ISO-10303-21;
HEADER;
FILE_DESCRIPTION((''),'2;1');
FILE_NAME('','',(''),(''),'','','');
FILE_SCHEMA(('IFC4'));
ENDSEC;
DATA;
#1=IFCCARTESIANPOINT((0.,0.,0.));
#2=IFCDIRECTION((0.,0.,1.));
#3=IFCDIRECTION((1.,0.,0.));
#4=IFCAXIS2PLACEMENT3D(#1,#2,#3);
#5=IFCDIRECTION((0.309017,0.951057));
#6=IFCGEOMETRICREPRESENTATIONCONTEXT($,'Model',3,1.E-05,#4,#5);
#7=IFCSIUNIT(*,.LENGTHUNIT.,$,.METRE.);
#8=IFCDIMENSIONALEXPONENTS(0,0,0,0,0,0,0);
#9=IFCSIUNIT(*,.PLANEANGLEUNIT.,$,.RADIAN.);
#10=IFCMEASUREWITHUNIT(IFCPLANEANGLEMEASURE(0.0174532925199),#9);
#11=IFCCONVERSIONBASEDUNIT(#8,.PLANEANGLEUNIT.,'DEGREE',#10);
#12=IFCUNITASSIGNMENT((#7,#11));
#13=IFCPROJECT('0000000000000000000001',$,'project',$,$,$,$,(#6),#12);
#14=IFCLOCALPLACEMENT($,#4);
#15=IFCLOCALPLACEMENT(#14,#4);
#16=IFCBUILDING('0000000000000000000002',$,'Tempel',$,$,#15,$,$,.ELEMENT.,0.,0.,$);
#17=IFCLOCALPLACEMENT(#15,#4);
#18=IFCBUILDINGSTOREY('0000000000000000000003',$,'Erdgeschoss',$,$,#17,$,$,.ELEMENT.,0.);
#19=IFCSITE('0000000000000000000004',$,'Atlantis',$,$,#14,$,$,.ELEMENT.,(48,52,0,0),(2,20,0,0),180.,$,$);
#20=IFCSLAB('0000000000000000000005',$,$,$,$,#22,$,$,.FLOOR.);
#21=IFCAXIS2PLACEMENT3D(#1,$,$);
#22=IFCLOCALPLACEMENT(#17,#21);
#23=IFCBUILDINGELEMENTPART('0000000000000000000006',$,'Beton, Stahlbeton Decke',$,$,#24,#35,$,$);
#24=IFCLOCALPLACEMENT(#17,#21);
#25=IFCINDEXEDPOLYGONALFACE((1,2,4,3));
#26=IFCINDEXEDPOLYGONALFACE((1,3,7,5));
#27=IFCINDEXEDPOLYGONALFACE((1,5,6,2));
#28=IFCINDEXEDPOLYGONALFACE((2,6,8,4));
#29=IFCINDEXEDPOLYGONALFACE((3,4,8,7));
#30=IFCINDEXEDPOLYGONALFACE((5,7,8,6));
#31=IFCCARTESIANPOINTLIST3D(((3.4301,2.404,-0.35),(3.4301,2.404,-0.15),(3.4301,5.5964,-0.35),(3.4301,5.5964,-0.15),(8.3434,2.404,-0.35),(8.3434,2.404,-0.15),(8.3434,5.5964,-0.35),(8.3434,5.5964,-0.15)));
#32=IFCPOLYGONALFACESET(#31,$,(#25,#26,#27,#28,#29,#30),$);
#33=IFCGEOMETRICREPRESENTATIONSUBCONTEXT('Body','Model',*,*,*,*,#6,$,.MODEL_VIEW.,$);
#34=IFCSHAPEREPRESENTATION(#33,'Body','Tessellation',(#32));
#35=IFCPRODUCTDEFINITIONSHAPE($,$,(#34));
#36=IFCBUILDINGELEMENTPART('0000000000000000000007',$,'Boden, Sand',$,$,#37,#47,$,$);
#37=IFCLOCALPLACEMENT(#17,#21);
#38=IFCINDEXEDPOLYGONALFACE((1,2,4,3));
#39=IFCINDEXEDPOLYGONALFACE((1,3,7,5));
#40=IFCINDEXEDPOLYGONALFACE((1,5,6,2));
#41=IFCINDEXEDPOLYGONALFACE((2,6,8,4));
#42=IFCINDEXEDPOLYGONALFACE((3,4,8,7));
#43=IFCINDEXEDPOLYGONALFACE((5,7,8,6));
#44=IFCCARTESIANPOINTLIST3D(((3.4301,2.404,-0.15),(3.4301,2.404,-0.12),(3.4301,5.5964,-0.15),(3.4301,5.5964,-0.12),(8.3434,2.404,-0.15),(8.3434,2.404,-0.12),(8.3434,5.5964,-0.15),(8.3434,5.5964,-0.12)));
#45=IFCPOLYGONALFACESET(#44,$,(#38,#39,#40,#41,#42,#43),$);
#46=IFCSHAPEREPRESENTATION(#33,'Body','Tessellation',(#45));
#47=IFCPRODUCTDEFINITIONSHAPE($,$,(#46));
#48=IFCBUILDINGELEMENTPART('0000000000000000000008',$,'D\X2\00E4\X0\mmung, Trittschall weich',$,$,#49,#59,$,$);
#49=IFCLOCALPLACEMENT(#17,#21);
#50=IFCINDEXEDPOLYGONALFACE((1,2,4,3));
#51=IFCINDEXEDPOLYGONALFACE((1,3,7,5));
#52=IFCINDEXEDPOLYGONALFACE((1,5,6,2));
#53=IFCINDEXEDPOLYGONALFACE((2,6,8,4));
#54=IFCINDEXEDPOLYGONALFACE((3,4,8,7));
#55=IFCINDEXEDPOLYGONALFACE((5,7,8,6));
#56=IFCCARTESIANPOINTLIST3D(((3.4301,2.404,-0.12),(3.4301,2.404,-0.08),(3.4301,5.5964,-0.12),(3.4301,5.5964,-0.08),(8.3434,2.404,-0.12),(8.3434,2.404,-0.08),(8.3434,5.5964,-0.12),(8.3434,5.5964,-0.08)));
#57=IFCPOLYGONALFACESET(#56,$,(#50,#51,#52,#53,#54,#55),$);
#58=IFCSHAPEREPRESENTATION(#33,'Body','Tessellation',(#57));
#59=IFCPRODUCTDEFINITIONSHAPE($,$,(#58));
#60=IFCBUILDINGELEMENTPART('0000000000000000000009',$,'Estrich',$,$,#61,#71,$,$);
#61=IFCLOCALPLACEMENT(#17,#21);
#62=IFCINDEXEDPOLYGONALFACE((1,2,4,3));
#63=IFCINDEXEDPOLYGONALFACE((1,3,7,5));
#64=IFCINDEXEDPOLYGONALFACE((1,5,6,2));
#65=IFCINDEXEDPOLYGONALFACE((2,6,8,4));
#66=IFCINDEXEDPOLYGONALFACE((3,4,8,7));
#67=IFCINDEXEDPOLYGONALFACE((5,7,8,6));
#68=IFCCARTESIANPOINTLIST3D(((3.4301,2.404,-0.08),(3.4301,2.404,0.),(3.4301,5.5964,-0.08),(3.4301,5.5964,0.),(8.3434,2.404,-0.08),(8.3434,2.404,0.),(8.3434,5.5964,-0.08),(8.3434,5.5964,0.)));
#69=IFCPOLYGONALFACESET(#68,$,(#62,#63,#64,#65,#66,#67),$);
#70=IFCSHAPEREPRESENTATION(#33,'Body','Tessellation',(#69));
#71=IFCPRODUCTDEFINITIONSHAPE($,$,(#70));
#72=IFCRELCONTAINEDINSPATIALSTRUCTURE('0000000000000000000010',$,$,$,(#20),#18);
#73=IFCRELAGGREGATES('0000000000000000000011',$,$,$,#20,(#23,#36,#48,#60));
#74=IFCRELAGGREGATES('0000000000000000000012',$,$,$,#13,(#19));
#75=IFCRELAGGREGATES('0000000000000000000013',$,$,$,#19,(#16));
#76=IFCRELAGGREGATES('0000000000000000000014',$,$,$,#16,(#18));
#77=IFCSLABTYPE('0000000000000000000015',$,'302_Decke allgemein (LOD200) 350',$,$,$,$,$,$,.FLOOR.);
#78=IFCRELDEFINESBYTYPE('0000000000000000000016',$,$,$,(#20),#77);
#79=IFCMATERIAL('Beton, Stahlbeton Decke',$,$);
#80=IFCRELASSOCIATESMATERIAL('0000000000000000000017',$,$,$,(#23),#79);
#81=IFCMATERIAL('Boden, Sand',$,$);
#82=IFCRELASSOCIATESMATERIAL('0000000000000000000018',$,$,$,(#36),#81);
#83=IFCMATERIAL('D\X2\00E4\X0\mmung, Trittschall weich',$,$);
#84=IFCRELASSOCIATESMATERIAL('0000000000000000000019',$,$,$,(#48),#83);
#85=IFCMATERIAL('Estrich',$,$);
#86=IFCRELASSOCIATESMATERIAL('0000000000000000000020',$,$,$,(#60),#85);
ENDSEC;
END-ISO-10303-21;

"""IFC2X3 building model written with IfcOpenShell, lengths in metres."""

from ifc_helpers import new_model, entity, si_unit, converted_unit, direction, frame, origin_with_axes, place, context, subcontext, project, spatial, polyline, outline, extrude, material, type_object, element, aggregate, save


model = new_model("IFC2X3")

# Units and contexts
model_context = context("Model", 3, precision=1e-05, world=origin_with_axes(), true_north=direction((0.309017, 0.951057)))
body_context = subcontext(model_context, "Body", "Model", "MODEL_VIEW")
ifc_project = project(units=[si_unit("LENGTHUNIT", "METRE"), converted_unit("PLANEANGLEUNIT", "DEGREE", entity("IfcPlaneAngleMeasure", 0.0174532925199), si_unit("PLANEANGLEUNIT", "RADIAN"), dimensions=[0, 0, 0, 0, 0, 0, 0])], contexts=[model_context])

# Site, building, storey
site_placement = place(None, origin_with_axes())
site = spatial("IfcSite", under=ifc_project, at=site_placement, Name="Atlantis", CompositionType="ELEMENT", RefLatitude=(48, 52, 0, 0), RefLongitude=(2, 20, 0, 0), RefElevation=180.0)
building_placement = place(site_placement, origin_with_axes())
building = spatial("IfcBuilding", under=site, at=building_placement, Name="Tempel", CompositionType="ELEMENT", ElevationOfRefHeight=0.0, ElevationOfTerrain=0.0)
storey_placement = place(building_placement, origin_with_axes())
storey = spatial("IfcBuildingStorey", under=building, at=storey_placement, Name="Erdgeschoss", CompositionType="ELEMENT", Elevation=0.0)

# Slab, building element parts
slab_type = type_object("IfcSlabType", Name="302_Decke allgemein (LOD200) 350", PredefinedType="FLOOR")
slab_placement = place(storey_placement, frame((3.4301, 2.404, -0.15), z_axis=(0.0, 0.0, 1.0), x_axis=(1.0, 0.0, 0.0)))
slab = element("IfcSlab", 1, at=slab_placement, inside=storey, type_object=slab_type, PredefinedType="FLOOR")
ifc_material_1 = material(Name="Beton, Stahlbeton Decke")
building_element_part_1_placement = place(slab_placement, origin_with_axes())
building_element_part_1 = element("IfcBuildingElementPart", 2, at=building_element_part_1_placement, material=ifc_material_1, Name="Beton, Stahlbeton Decke", context=body_context, shape_type="SweptSolid", body=[
    extrude(outline(polyline([(0.0, 0.0), (4.9133, 0.0), (4.9133, 3.1924), (0.0, 3.1924), (0.0, 0.0)])), frame((0.0, 0.0, -0.2), z_axis=(0.0, 0.0, 1.0), x_axis=(1.0, 0.0, 0.0)), (0.0, 0.0, 1.0), 0.2),
])
ifc_material_2 = material(Name="Boden, Sand")
building_element_part_2_placement = place(slab_placement, origin_with_axes())
building_element_part_2 = element("IfcBuildingElementPart", 3, at=building_element_part_2_placement, material=ifc_material_2, Name="Boden, Sand", context=body_context, shape_type="SweptSolid", body=[
    extrude(outline(polyline([(0.0, 0.0), (4.9133, 0.0), (4.9133, 3.1924), (0.0, 3.1924), (0.0, 0.0)])), origin_with_axes(), (0.0, 0.0, 1.0), 0.03),
])
ifc_material_3 = material(Name="Dämmung, Trittschall weich")
building_element_part_3_placement = place(slab_placement, origin_with_axes())
building_element_part_3 = element("IfcBuildingElementPart", 4, at=building_element_part_3_placement, material=ifc_material_3, Name="Dämmung, Trittschall weich", context=body_context, shape_type="SweptSolid", body=[
    extrude(outline(polyline([(0.0, 0.0), (4.9133, 0.0), (4.9133, 3.1924), (0.0, 3.1924), (0.0, 0.0)])), frame((0.0, 0.0, 0.03), z_axis=(0.0, 0.0, 1.0), x_axis=(1.0, 0.0, 0.0)), (0.0, 0.0, 1.0), 0.04),
])
ifc_material_4 = material(Name="Estrich")
building_element_part_4_placement = place(slab_placement, origin_with_axes())
building_element_part_4 = element("IfcBuildingElementPart", 5, at=building_element_part_4_placement, material=ifc_material_4, Name="Estrich", context=body_context, shape_type="SweptSolid", body=[
    extrude(outline(polyline([(0.0, 0.0), (4.9133, 0.0), (4.9133, 3.1924), (0.0, 3.1924), (0.0, 0.0)])), frame((0.0, 0.0, 0.07), z_axis=(0.0, 0.0, 1.0), x_axis=(1.0, 0.0, 0.0)), (0.0, 0.0, 1.0), 0.08),
])
aggregate(slab, [building_element_part_1, building_element_part_2, building_element_part_3, building_element_part_4])

save(model, "model.ifc")
